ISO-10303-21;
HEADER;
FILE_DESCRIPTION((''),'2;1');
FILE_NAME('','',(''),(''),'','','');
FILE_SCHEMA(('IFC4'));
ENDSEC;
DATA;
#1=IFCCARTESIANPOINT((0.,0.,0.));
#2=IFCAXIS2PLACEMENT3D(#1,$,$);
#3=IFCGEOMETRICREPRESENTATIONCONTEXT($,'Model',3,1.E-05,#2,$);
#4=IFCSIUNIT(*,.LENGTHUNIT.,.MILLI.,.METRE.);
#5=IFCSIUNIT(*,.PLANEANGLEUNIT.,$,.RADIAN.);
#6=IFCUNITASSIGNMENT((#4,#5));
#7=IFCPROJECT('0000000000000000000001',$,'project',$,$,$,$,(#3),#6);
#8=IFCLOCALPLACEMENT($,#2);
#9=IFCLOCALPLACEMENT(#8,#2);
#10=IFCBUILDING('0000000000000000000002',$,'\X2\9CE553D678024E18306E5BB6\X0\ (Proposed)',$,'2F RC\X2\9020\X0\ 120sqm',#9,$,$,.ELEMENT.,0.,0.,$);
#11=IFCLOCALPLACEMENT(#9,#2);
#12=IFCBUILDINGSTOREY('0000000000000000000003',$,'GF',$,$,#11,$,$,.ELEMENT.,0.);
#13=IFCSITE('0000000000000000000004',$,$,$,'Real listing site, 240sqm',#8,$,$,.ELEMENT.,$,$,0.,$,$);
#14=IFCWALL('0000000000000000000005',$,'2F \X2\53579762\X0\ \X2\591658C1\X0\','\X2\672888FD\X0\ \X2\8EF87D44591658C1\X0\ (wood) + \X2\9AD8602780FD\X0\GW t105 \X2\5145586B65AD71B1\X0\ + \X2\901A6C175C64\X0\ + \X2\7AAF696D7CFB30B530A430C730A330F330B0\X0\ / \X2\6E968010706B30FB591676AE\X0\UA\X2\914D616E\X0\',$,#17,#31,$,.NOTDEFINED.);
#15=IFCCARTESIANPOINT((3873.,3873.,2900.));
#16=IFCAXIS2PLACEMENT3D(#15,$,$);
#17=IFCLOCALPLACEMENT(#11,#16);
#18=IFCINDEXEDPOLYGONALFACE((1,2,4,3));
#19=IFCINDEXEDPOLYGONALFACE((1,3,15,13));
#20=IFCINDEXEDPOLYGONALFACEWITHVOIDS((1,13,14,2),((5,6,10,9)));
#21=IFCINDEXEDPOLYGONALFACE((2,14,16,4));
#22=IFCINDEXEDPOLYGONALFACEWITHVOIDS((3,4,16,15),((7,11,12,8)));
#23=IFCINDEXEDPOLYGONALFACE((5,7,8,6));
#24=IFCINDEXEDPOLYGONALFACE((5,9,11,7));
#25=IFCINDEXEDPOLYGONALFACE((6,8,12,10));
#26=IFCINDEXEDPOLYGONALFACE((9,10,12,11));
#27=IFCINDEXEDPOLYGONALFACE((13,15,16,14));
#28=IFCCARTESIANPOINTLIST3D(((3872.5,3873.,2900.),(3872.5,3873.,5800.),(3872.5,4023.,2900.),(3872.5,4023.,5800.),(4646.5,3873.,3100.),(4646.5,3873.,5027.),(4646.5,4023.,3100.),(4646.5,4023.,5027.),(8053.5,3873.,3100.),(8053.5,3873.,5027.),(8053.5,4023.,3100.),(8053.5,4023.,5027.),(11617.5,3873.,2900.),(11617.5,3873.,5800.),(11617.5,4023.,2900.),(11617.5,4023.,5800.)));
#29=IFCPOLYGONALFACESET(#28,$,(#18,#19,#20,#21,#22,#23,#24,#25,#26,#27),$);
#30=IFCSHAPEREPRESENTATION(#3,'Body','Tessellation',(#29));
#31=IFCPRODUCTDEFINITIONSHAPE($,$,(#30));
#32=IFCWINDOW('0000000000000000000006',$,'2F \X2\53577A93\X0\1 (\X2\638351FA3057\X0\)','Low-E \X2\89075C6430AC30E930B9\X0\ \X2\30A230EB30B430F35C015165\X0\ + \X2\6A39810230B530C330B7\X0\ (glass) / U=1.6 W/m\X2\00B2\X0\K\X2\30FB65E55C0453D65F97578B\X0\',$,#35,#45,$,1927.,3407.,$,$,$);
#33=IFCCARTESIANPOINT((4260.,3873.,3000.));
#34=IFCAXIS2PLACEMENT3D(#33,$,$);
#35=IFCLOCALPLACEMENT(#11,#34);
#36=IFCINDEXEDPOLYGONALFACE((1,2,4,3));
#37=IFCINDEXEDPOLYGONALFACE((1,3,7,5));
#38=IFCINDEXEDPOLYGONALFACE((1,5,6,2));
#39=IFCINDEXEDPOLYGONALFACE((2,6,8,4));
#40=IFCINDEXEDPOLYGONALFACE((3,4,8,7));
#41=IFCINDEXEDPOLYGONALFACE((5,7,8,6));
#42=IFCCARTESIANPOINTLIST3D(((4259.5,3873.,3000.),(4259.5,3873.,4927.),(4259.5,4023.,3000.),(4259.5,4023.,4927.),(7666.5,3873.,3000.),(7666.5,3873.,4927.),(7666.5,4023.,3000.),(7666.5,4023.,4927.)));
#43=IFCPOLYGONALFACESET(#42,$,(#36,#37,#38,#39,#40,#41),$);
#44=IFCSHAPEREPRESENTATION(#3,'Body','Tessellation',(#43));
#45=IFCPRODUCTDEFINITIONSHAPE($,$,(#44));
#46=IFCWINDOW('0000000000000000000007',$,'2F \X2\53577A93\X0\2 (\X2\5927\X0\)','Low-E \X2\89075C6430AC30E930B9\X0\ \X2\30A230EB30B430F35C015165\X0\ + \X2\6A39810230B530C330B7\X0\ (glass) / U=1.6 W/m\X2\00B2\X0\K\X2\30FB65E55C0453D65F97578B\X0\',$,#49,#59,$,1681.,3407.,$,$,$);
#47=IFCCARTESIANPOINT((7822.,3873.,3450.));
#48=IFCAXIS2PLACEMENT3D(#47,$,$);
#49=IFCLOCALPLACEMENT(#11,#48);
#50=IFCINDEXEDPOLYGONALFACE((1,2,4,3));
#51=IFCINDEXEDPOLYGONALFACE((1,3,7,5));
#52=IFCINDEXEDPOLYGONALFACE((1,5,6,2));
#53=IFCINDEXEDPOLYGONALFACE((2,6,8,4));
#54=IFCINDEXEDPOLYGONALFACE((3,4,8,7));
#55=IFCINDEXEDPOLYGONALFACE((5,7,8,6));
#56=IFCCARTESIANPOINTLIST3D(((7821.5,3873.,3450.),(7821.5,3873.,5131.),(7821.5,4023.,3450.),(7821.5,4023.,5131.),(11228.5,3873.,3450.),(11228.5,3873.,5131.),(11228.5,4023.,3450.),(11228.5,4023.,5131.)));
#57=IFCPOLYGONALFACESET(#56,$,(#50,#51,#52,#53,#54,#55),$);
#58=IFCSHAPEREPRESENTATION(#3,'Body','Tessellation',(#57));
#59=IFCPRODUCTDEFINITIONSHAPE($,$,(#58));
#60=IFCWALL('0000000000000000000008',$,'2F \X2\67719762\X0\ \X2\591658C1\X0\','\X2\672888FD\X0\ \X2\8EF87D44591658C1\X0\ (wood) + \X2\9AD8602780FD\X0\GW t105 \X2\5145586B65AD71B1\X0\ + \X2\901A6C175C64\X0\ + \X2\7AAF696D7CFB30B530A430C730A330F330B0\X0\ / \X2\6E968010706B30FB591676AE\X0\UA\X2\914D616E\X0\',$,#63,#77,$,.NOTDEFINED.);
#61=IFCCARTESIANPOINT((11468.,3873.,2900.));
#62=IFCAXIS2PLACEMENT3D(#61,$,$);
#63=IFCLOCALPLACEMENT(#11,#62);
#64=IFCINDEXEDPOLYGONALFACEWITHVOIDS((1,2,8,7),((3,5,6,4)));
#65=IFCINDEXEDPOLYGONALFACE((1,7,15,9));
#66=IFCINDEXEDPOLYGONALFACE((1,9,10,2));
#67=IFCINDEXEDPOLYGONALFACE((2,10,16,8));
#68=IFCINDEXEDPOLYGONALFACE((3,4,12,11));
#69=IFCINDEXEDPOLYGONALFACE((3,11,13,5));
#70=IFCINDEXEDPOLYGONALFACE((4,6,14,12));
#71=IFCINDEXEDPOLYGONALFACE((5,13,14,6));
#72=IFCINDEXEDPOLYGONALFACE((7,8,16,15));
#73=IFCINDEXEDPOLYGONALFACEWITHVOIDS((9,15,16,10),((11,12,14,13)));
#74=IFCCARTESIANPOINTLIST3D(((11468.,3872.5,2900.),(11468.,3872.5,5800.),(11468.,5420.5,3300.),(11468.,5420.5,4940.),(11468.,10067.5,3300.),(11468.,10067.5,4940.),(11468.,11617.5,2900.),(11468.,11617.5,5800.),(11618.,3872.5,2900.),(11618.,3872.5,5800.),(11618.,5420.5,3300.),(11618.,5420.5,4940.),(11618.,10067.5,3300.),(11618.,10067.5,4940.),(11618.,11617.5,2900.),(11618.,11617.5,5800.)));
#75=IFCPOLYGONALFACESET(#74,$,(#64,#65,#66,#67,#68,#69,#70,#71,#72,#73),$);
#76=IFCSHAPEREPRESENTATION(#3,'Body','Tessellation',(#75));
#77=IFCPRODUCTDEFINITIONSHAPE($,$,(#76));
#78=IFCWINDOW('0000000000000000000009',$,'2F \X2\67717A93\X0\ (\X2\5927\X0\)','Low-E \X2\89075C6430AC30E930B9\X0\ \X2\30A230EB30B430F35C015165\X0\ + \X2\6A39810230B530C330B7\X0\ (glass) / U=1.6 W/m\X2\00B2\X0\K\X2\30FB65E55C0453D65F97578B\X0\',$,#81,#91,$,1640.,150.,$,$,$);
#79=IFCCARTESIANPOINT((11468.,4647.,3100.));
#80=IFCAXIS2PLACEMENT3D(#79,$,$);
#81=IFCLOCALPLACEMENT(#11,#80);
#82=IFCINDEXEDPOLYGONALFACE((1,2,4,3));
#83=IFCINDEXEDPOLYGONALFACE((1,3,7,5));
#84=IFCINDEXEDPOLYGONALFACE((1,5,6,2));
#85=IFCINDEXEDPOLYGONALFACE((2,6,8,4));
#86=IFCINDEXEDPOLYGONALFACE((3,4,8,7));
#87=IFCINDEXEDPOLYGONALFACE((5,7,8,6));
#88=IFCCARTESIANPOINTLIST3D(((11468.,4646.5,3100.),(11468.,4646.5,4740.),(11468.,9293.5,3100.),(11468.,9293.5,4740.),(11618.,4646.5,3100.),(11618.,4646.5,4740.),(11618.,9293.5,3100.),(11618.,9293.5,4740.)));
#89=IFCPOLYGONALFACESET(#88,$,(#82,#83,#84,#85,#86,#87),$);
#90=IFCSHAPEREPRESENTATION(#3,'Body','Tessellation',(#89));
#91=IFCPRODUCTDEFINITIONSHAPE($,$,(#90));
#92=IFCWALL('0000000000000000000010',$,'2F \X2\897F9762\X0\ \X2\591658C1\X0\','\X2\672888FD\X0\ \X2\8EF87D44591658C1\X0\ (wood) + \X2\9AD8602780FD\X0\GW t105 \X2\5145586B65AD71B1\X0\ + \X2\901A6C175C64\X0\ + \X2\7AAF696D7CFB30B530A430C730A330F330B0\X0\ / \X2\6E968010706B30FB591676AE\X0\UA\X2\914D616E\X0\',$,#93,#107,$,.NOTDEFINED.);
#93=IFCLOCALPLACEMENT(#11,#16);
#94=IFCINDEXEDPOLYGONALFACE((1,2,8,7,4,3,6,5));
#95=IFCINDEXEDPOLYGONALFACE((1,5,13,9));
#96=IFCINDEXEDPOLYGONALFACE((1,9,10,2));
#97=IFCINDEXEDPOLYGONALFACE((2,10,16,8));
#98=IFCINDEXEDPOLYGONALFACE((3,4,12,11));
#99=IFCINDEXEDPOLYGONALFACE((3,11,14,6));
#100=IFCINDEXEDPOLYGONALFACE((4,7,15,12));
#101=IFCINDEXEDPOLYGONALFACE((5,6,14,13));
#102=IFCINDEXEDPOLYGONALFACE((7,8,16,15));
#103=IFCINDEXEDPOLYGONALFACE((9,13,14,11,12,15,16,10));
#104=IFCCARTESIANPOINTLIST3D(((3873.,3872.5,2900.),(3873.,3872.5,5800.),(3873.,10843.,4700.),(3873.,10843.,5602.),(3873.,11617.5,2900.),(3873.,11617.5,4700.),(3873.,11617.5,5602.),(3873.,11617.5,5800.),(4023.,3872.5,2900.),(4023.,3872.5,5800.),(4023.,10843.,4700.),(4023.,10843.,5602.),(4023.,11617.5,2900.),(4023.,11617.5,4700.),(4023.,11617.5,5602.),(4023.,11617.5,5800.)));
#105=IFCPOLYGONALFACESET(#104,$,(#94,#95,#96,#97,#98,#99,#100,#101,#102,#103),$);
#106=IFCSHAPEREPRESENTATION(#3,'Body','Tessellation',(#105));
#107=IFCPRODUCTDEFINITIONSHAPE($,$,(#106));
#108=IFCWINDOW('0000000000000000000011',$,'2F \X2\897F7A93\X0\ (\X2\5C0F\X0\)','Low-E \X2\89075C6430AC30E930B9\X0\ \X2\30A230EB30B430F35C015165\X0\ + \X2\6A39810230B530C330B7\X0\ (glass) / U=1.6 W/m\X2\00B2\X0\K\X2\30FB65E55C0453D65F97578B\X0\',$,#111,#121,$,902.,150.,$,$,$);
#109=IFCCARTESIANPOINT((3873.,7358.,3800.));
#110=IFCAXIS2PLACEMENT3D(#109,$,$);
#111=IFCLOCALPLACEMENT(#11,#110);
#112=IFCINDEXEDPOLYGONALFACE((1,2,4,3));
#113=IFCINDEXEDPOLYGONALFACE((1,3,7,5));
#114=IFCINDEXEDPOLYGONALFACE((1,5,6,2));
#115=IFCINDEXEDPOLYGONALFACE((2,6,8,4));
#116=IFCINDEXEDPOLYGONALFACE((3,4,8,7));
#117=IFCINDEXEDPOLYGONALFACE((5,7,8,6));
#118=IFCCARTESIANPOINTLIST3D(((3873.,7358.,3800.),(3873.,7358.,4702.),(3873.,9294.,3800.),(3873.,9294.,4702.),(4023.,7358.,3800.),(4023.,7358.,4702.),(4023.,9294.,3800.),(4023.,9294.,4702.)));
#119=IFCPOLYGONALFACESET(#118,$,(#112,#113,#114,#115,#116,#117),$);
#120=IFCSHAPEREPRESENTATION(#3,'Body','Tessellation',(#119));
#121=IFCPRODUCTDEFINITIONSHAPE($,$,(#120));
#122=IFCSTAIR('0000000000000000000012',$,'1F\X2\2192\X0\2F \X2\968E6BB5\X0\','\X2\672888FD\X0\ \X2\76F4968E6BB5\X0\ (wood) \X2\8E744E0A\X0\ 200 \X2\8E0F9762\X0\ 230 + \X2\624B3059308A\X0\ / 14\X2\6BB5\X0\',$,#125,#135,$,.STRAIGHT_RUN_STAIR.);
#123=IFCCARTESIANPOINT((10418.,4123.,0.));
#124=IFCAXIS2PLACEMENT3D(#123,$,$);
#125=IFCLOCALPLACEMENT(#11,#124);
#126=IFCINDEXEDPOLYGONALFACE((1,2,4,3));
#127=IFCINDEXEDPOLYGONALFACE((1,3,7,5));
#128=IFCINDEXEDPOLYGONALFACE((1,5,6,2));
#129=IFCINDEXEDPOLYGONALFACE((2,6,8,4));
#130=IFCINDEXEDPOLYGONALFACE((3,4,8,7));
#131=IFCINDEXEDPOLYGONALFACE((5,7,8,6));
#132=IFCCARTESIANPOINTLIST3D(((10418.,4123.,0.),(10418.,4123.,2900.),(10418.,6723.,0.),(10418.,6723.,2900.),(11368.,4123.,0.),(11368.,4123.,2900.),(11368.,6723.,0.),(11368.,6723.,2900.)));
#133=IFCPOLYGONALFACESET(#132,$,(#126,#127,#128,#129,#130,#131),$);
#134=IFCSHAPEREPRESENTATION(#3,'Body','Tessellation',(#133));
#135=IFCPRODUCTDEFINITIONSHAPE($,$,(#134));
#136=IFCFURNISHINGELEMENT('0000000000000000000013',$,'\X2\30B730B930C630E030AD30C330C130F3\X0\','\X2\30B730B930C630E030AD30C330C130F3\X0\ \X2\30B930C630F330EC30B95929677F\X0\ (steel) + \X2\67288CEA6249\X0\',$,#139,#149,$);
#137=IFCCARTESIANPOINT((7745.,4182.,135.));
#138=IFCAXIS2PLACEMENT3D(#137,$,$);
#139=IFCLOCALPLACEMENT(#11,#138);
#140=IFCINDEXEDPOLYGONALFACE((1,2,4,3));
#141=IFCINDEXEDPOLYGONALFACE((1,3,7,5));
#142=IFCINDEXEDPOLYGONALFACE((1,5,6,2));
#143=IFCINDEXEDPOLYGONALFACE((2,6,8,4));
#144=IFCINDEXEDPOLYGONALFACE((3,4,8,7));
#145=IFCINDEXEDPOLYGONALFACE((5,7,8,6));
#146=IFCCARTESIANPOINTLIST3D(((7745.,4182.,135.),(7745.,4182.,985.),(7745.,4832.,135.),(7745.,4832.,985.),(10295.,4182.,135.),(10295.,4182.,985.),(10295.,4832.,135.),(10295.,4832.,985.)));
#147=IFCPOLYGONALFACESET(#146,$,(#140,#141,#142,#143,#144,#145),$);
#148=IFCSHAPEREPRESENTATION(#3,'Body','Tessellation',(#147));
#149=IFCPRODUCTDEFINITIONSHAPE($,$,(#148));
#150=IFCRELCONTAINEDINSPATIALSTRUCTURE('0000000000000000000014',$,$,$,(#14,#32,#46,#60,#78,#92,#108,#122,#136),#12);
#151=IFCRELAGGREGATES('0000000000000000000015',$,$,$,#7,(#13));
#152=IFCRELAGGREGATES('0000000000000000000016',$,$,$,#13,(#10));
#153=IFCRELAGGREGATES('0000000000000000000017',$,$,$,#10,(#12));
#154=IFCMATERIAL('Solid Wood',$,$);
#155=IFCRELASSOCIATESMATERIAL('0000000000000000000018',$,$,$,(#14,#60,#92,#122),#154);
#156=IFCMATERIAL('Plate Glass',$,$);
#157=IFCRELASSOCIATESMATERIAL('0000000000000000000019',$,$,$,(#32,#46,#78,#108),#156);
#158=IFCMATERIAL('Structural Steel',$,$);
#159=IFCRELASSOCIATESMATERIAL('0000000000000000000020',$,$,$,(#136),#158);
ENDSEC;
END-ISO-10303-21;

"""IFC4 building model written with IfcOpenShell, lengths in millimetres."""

from ifc_helpers import new_model, si_unit, frame, frame_2d, origin, place, context, project, spatial, rectangle, extrude, material, element, fill, save


model = new_model("IFC4")

# Units and contexts
model_context = context("Model", 3, precision=1e-05, world=origin())
ifc_project = project(units=[si_unit("LENGTHUNIT", "METRE", prefix="MILLI"), si_unit("PLANEANGLEUNIT", "RADIAN")], contexts=[model_context])

# Site, building, storey
site_placement = place(None, origin())
site = spatial("IfcSite", under=ifc_project, at=site_placement, ObjectType="Real listing site, 240sqm", CompositionType="ELEMENT", RefElevation=0.0)
building_placement = place(site_placement, origin())
building = spatial("IfcBuilding", under=site, at=building_placement, Name="鳥取砂丘の家 (Proposed)", ObjectType="2F RC造 120sqm", CompositionType="ELEMENT", ElevationOfRefHeight=0.0, ElevationOfTerrain=0.0)
storey_placement = place(building_placement, origin())
storey = spatial("IfcBuildingStorey", under=building, at=storey_placement, Name="GF", CompositionType="ELEMENT", Elevation=0.0)

# Shared definitions
ifc_material_1 = material(Name="Solid Wood")

# Shared definitions
ifc_material_2 = material(Name="Plate Glass")

# Wall, openings, windows
wall_1_placement = place(storey_placement, frame((3873.0, 3873.0, 2900.0)))
wall_1 = element("IfcWall", 1, at=wall_1_placement, inside=storey, material=ifc_material_1, Name="2F 南面 外壁", Description="木製 軸組外壁 (wood) + 高性能GW t105 充填断熱 + 通気層 + 窯業系サイディング / 準耐火・外皮UA配慮", PredefinedType="NOTDEFINED", context=model_context, shape_type="SweptSolid", body=[
    extrude(rectangle(XDim=7745.0, YDim=150.0, at=frame_2d((3872.0, 75.0))), frame((3873.0, 3873.0, 2900.0)), (0.0, 0.0, 1.0), 2900.0),
])
opening_1_placement = place(storey_placement, frame((4260.0, 3873.0, 3000.0)))
opening_1 = element("IfcOpeningElement", 2, at=opening_1_placement, cuts=wall_1, PredefinedType="NOTDEFINED", context=model_context, shape_type="SweptSolid", body=[
    extrude(rectangle(XDim=3407.0, YDim=150.0, at=frame_2d((1703.0, 75.0))), frame((4260.0, 3873.0, 3000.0)), (0.0, 0.0, 1.0), 1927.0),
])
opening_2_placement = place(storey_placement, frame((7822.0, 3873.0, 3450.0)))
opening_2 = element("IfcOpeningElement", 3, at=opening_2_placement, cuts=wall_1, PredefinedType="NOTDEFINED", context=model_context, shape_type="SweptSolid", body=[
    extrude(rectangle(XDim=3407.0, YDim=150.0, at=frame_2d((1703.0, 75.0))), frame((7822.0, 3873.0, 3450.0)), (0.0, 0.0, 1.0), 1681.0),
])
window_1_placement = place(storey_placement, frame((4260.0, 3873.0, 3000.0)))
window_1 = element("IfcWindow", 4, at=window_1_placement, inside=storey, material=ifc_material_2, Name="2F 南窓1 (掃出し)", Description="Low-E 複層ガラス アルゴン封入 + 樹脂サッシ (glass) / U=1.6 W/m²K・日射取得型", OverallHeight=1927.0, OverallWidth=3407.0, context=model_context, shape_type="SweptSolid", body=[
    extrude(rectangle(XDim=3407.0, YDim=150.0, at=frame_2d((1703.0, 75.0))), frame((4260.0, 3873.0, 3000.0)), (0.0, 0.0, 1.0), 1927.0),
])
fill(opening_1, window_1)
window_2_placement = place(storey_placement, frame((7822.0, 3873.0, 3450.0)))
window_2 = element("IfcWindow", 5, at=window_2_placement, inside=storey, material=ifc_material_2, Name="2F 南窓2 (大)", Description="Low-E 複層ガラス アルゴン封入 + 樹脂サッシ (glass) / U=1.6 W/m²K・日射取得型", OverallHeight=1681.0, OverallWidth=3407.0, context=model_context, shape_type="SweptSolid", body=[
    extrude(rectangle(XDim=3407.0, YDim=150.0, at=frame_2d((1703.0, 75.0))), frame((7822.0, 3873.0, 3450.0)), (0.0, 0.0, 1.0), 1681.0),
])
fill(opening_2, window_2)

# Walls, openings, windows
wall_2_placement = place(storey_placement, frame((11468.0, 3873.0, 2900.0)))
wall_2 = element("IfcWall", 6, at=wall_2_placement, inside=storey, material=ifc_material_1, Name="2F 東面 外壁", Description="木製 軸組外壁 (wood) + 高性能GW t105 充填断熱 + 通気層 + 窯業系サイディング / 準耐火・外皮UA配慮", PredefinedType="NOTDEFINED", context=model_context, shape_type="SweptSolid", body=[
    extrude(rectangle(XDim=150.0, YDim=7745.0, at=frame_2d((75.0, 3872.0))), frame((11468.0, 3873.0, 2900.0)), (0.0, 0.0, 1.0), 2900.0),
])
opening_3_placement = place(storey_placement, frame((11468.0, 4647.0, 3100.0)))
opening_3 = element("IfcOpeningElement", 7, at=opening_3_placement, cuts=wall_2, PredefinedType="NOTDEFINED", context=model_context, shape_type="SweptSolid", body=[
    extrude(rectangle(XDim=150.0, YDim=4647.0, at=frame_2d((75.0, 2323.0))), frame((11468.0, 4647.0, 3100.0)), (0.0, 0.0, 1.0), 1640.0),
])
window_3_placement = place(storey_placement, frame((11468.0, 4647.0, 3100.0)))
window_3 = element("IfcWindow", 8, at=window_3_placement, inside=storey, material=ifc_material_2, Name="2F 東窓 (大)", Description="Low-E 複層ガラス アルゴン封入 + 樹脂サッシ (glass) / U=1.6 W/m²K・日射取得型", OverallHeight=1640.0, OverallWidth=150.0, context=model_context, shape_type="SweptSolid", body=[
    extrude(rectangle(XDim=150.0, YDim=4647.0, at=frame_2d((75.0, 2323.0))), frame((11468.0, 4647.0, 3100.0)), (0.0, 0.0, 1.0), 1640.0),
])
fill(opening_3, window_3)
wall_3_placement = place(storey_placement, frame((3873.0, 3873.0, 2900.0)))
wall_3 = element("IfcWall", 9, at=wall_3_placement, inside=storey, material=ifc_material_1, Name="2F 西面 外壁", Description="木製 軸組外壁 (wood) + 高性能GW t105 充填断熱 + 通気層 + 窯業系サイディング / 準耐火・外皮UA配慮", PredefinedType="NOTDEFINED", context=model_context, shape_type="SweptSolid", body=[
    extrude(rectangle(XDim=150.0, YDim=7745.0, at=frame_2d((75.0, 3872.0))), frame((3873.0, 3873.0, 2900.0)), (0.0, 0.0, 1.0), 2900.0),
])
opening_4_placement = place(storey_placement, frame((3873.0, 7358.0, 3800.0)))
opening_4 = element("IfcOpeningElement", 10, at=opening_4_placement, cuts=wall_3, PredefinedType="NOTDEFINED", context=model_context, shape_type="SweptSolid", body=[
    extrude(rectangle(XDim=150.0, YDim=1936.0, at=frame_2d((75.0, 968.0))), frame((3873.0, 7358.0, 3800.0)), (0.0, 0.0, 1.0), 902.0),
])
window_4_placement = place(storey_placement, frame((3873.0, 7358.0, 3800.0)))
window_4 = element("IfcWindow", 11, at=window_4_placement, inside=storey, material=ifc_material_2, Name="2F 西窓 (小)", Description="Low-E 複層ガラス アルゴン封入 + 樹脂サッシ (glass) / U=1.6 W/m²K・日射取得型", OverallHeight=902.0, OverallWidth=150.0, context=model_context, shape_type="SweptSolid", body=[
    extrude(rectangle(XDim=150.0, YDim=1936.0, at=frame_2d((75.0, 968.0))), frame((3873.0, 7358.0, 3800.0)), (0.0, 0.0, 1.0), 902.0),
])
fill(opening_4, window_4)

# Stair
stair_placement = place(storey_placement, frame((10418.0, 4123.0, 0.0)))
element("IfcStair", 12, at=stair_placement, inside=storey, material=ifc_material_1, Name="1F→2F 階段", Description="木製 直階段 (wood) 蹴上 200 踏面 230 + 手すり / 14段", PredefinedType="STRAIGHT_RUN_STAIR", context=model_context, shape_type="SweptSolid", body=[
    extrude(rectangle(XDim=950.0, YDim=2600.0, at=frame_2d((475.0, 1300.0))), frame((10418.0, 4123.0, 0.0)), (0.0, 0.0, 1.0), 2900.0),
])

# Shared definitions
ifc_material_3 = material(Name="Structural Steel")

# Furnishing element
furnishing_placement = place(storey_placement, frame((7745.0, 4182.0, 135.0)))
element("IfcFurnishingElement", 13, at=furnishing_placement, inside=storey, material=ifc_material_3, Name="システムキッチン", Description="システムキッチン ステンレス天板 (steel) + 木質扉", context=model_context, shape_type="SweptSolid", body=[
    extrude(rectangle(XDim=2550.0, YDim=650.0, at=frame_2d((1275.0, 325.0))), frame((7745.0, 4182.0, 135.0)), (0.0, 0.0, 1.0), 850.0),
])

save(model, "model.ifc")
